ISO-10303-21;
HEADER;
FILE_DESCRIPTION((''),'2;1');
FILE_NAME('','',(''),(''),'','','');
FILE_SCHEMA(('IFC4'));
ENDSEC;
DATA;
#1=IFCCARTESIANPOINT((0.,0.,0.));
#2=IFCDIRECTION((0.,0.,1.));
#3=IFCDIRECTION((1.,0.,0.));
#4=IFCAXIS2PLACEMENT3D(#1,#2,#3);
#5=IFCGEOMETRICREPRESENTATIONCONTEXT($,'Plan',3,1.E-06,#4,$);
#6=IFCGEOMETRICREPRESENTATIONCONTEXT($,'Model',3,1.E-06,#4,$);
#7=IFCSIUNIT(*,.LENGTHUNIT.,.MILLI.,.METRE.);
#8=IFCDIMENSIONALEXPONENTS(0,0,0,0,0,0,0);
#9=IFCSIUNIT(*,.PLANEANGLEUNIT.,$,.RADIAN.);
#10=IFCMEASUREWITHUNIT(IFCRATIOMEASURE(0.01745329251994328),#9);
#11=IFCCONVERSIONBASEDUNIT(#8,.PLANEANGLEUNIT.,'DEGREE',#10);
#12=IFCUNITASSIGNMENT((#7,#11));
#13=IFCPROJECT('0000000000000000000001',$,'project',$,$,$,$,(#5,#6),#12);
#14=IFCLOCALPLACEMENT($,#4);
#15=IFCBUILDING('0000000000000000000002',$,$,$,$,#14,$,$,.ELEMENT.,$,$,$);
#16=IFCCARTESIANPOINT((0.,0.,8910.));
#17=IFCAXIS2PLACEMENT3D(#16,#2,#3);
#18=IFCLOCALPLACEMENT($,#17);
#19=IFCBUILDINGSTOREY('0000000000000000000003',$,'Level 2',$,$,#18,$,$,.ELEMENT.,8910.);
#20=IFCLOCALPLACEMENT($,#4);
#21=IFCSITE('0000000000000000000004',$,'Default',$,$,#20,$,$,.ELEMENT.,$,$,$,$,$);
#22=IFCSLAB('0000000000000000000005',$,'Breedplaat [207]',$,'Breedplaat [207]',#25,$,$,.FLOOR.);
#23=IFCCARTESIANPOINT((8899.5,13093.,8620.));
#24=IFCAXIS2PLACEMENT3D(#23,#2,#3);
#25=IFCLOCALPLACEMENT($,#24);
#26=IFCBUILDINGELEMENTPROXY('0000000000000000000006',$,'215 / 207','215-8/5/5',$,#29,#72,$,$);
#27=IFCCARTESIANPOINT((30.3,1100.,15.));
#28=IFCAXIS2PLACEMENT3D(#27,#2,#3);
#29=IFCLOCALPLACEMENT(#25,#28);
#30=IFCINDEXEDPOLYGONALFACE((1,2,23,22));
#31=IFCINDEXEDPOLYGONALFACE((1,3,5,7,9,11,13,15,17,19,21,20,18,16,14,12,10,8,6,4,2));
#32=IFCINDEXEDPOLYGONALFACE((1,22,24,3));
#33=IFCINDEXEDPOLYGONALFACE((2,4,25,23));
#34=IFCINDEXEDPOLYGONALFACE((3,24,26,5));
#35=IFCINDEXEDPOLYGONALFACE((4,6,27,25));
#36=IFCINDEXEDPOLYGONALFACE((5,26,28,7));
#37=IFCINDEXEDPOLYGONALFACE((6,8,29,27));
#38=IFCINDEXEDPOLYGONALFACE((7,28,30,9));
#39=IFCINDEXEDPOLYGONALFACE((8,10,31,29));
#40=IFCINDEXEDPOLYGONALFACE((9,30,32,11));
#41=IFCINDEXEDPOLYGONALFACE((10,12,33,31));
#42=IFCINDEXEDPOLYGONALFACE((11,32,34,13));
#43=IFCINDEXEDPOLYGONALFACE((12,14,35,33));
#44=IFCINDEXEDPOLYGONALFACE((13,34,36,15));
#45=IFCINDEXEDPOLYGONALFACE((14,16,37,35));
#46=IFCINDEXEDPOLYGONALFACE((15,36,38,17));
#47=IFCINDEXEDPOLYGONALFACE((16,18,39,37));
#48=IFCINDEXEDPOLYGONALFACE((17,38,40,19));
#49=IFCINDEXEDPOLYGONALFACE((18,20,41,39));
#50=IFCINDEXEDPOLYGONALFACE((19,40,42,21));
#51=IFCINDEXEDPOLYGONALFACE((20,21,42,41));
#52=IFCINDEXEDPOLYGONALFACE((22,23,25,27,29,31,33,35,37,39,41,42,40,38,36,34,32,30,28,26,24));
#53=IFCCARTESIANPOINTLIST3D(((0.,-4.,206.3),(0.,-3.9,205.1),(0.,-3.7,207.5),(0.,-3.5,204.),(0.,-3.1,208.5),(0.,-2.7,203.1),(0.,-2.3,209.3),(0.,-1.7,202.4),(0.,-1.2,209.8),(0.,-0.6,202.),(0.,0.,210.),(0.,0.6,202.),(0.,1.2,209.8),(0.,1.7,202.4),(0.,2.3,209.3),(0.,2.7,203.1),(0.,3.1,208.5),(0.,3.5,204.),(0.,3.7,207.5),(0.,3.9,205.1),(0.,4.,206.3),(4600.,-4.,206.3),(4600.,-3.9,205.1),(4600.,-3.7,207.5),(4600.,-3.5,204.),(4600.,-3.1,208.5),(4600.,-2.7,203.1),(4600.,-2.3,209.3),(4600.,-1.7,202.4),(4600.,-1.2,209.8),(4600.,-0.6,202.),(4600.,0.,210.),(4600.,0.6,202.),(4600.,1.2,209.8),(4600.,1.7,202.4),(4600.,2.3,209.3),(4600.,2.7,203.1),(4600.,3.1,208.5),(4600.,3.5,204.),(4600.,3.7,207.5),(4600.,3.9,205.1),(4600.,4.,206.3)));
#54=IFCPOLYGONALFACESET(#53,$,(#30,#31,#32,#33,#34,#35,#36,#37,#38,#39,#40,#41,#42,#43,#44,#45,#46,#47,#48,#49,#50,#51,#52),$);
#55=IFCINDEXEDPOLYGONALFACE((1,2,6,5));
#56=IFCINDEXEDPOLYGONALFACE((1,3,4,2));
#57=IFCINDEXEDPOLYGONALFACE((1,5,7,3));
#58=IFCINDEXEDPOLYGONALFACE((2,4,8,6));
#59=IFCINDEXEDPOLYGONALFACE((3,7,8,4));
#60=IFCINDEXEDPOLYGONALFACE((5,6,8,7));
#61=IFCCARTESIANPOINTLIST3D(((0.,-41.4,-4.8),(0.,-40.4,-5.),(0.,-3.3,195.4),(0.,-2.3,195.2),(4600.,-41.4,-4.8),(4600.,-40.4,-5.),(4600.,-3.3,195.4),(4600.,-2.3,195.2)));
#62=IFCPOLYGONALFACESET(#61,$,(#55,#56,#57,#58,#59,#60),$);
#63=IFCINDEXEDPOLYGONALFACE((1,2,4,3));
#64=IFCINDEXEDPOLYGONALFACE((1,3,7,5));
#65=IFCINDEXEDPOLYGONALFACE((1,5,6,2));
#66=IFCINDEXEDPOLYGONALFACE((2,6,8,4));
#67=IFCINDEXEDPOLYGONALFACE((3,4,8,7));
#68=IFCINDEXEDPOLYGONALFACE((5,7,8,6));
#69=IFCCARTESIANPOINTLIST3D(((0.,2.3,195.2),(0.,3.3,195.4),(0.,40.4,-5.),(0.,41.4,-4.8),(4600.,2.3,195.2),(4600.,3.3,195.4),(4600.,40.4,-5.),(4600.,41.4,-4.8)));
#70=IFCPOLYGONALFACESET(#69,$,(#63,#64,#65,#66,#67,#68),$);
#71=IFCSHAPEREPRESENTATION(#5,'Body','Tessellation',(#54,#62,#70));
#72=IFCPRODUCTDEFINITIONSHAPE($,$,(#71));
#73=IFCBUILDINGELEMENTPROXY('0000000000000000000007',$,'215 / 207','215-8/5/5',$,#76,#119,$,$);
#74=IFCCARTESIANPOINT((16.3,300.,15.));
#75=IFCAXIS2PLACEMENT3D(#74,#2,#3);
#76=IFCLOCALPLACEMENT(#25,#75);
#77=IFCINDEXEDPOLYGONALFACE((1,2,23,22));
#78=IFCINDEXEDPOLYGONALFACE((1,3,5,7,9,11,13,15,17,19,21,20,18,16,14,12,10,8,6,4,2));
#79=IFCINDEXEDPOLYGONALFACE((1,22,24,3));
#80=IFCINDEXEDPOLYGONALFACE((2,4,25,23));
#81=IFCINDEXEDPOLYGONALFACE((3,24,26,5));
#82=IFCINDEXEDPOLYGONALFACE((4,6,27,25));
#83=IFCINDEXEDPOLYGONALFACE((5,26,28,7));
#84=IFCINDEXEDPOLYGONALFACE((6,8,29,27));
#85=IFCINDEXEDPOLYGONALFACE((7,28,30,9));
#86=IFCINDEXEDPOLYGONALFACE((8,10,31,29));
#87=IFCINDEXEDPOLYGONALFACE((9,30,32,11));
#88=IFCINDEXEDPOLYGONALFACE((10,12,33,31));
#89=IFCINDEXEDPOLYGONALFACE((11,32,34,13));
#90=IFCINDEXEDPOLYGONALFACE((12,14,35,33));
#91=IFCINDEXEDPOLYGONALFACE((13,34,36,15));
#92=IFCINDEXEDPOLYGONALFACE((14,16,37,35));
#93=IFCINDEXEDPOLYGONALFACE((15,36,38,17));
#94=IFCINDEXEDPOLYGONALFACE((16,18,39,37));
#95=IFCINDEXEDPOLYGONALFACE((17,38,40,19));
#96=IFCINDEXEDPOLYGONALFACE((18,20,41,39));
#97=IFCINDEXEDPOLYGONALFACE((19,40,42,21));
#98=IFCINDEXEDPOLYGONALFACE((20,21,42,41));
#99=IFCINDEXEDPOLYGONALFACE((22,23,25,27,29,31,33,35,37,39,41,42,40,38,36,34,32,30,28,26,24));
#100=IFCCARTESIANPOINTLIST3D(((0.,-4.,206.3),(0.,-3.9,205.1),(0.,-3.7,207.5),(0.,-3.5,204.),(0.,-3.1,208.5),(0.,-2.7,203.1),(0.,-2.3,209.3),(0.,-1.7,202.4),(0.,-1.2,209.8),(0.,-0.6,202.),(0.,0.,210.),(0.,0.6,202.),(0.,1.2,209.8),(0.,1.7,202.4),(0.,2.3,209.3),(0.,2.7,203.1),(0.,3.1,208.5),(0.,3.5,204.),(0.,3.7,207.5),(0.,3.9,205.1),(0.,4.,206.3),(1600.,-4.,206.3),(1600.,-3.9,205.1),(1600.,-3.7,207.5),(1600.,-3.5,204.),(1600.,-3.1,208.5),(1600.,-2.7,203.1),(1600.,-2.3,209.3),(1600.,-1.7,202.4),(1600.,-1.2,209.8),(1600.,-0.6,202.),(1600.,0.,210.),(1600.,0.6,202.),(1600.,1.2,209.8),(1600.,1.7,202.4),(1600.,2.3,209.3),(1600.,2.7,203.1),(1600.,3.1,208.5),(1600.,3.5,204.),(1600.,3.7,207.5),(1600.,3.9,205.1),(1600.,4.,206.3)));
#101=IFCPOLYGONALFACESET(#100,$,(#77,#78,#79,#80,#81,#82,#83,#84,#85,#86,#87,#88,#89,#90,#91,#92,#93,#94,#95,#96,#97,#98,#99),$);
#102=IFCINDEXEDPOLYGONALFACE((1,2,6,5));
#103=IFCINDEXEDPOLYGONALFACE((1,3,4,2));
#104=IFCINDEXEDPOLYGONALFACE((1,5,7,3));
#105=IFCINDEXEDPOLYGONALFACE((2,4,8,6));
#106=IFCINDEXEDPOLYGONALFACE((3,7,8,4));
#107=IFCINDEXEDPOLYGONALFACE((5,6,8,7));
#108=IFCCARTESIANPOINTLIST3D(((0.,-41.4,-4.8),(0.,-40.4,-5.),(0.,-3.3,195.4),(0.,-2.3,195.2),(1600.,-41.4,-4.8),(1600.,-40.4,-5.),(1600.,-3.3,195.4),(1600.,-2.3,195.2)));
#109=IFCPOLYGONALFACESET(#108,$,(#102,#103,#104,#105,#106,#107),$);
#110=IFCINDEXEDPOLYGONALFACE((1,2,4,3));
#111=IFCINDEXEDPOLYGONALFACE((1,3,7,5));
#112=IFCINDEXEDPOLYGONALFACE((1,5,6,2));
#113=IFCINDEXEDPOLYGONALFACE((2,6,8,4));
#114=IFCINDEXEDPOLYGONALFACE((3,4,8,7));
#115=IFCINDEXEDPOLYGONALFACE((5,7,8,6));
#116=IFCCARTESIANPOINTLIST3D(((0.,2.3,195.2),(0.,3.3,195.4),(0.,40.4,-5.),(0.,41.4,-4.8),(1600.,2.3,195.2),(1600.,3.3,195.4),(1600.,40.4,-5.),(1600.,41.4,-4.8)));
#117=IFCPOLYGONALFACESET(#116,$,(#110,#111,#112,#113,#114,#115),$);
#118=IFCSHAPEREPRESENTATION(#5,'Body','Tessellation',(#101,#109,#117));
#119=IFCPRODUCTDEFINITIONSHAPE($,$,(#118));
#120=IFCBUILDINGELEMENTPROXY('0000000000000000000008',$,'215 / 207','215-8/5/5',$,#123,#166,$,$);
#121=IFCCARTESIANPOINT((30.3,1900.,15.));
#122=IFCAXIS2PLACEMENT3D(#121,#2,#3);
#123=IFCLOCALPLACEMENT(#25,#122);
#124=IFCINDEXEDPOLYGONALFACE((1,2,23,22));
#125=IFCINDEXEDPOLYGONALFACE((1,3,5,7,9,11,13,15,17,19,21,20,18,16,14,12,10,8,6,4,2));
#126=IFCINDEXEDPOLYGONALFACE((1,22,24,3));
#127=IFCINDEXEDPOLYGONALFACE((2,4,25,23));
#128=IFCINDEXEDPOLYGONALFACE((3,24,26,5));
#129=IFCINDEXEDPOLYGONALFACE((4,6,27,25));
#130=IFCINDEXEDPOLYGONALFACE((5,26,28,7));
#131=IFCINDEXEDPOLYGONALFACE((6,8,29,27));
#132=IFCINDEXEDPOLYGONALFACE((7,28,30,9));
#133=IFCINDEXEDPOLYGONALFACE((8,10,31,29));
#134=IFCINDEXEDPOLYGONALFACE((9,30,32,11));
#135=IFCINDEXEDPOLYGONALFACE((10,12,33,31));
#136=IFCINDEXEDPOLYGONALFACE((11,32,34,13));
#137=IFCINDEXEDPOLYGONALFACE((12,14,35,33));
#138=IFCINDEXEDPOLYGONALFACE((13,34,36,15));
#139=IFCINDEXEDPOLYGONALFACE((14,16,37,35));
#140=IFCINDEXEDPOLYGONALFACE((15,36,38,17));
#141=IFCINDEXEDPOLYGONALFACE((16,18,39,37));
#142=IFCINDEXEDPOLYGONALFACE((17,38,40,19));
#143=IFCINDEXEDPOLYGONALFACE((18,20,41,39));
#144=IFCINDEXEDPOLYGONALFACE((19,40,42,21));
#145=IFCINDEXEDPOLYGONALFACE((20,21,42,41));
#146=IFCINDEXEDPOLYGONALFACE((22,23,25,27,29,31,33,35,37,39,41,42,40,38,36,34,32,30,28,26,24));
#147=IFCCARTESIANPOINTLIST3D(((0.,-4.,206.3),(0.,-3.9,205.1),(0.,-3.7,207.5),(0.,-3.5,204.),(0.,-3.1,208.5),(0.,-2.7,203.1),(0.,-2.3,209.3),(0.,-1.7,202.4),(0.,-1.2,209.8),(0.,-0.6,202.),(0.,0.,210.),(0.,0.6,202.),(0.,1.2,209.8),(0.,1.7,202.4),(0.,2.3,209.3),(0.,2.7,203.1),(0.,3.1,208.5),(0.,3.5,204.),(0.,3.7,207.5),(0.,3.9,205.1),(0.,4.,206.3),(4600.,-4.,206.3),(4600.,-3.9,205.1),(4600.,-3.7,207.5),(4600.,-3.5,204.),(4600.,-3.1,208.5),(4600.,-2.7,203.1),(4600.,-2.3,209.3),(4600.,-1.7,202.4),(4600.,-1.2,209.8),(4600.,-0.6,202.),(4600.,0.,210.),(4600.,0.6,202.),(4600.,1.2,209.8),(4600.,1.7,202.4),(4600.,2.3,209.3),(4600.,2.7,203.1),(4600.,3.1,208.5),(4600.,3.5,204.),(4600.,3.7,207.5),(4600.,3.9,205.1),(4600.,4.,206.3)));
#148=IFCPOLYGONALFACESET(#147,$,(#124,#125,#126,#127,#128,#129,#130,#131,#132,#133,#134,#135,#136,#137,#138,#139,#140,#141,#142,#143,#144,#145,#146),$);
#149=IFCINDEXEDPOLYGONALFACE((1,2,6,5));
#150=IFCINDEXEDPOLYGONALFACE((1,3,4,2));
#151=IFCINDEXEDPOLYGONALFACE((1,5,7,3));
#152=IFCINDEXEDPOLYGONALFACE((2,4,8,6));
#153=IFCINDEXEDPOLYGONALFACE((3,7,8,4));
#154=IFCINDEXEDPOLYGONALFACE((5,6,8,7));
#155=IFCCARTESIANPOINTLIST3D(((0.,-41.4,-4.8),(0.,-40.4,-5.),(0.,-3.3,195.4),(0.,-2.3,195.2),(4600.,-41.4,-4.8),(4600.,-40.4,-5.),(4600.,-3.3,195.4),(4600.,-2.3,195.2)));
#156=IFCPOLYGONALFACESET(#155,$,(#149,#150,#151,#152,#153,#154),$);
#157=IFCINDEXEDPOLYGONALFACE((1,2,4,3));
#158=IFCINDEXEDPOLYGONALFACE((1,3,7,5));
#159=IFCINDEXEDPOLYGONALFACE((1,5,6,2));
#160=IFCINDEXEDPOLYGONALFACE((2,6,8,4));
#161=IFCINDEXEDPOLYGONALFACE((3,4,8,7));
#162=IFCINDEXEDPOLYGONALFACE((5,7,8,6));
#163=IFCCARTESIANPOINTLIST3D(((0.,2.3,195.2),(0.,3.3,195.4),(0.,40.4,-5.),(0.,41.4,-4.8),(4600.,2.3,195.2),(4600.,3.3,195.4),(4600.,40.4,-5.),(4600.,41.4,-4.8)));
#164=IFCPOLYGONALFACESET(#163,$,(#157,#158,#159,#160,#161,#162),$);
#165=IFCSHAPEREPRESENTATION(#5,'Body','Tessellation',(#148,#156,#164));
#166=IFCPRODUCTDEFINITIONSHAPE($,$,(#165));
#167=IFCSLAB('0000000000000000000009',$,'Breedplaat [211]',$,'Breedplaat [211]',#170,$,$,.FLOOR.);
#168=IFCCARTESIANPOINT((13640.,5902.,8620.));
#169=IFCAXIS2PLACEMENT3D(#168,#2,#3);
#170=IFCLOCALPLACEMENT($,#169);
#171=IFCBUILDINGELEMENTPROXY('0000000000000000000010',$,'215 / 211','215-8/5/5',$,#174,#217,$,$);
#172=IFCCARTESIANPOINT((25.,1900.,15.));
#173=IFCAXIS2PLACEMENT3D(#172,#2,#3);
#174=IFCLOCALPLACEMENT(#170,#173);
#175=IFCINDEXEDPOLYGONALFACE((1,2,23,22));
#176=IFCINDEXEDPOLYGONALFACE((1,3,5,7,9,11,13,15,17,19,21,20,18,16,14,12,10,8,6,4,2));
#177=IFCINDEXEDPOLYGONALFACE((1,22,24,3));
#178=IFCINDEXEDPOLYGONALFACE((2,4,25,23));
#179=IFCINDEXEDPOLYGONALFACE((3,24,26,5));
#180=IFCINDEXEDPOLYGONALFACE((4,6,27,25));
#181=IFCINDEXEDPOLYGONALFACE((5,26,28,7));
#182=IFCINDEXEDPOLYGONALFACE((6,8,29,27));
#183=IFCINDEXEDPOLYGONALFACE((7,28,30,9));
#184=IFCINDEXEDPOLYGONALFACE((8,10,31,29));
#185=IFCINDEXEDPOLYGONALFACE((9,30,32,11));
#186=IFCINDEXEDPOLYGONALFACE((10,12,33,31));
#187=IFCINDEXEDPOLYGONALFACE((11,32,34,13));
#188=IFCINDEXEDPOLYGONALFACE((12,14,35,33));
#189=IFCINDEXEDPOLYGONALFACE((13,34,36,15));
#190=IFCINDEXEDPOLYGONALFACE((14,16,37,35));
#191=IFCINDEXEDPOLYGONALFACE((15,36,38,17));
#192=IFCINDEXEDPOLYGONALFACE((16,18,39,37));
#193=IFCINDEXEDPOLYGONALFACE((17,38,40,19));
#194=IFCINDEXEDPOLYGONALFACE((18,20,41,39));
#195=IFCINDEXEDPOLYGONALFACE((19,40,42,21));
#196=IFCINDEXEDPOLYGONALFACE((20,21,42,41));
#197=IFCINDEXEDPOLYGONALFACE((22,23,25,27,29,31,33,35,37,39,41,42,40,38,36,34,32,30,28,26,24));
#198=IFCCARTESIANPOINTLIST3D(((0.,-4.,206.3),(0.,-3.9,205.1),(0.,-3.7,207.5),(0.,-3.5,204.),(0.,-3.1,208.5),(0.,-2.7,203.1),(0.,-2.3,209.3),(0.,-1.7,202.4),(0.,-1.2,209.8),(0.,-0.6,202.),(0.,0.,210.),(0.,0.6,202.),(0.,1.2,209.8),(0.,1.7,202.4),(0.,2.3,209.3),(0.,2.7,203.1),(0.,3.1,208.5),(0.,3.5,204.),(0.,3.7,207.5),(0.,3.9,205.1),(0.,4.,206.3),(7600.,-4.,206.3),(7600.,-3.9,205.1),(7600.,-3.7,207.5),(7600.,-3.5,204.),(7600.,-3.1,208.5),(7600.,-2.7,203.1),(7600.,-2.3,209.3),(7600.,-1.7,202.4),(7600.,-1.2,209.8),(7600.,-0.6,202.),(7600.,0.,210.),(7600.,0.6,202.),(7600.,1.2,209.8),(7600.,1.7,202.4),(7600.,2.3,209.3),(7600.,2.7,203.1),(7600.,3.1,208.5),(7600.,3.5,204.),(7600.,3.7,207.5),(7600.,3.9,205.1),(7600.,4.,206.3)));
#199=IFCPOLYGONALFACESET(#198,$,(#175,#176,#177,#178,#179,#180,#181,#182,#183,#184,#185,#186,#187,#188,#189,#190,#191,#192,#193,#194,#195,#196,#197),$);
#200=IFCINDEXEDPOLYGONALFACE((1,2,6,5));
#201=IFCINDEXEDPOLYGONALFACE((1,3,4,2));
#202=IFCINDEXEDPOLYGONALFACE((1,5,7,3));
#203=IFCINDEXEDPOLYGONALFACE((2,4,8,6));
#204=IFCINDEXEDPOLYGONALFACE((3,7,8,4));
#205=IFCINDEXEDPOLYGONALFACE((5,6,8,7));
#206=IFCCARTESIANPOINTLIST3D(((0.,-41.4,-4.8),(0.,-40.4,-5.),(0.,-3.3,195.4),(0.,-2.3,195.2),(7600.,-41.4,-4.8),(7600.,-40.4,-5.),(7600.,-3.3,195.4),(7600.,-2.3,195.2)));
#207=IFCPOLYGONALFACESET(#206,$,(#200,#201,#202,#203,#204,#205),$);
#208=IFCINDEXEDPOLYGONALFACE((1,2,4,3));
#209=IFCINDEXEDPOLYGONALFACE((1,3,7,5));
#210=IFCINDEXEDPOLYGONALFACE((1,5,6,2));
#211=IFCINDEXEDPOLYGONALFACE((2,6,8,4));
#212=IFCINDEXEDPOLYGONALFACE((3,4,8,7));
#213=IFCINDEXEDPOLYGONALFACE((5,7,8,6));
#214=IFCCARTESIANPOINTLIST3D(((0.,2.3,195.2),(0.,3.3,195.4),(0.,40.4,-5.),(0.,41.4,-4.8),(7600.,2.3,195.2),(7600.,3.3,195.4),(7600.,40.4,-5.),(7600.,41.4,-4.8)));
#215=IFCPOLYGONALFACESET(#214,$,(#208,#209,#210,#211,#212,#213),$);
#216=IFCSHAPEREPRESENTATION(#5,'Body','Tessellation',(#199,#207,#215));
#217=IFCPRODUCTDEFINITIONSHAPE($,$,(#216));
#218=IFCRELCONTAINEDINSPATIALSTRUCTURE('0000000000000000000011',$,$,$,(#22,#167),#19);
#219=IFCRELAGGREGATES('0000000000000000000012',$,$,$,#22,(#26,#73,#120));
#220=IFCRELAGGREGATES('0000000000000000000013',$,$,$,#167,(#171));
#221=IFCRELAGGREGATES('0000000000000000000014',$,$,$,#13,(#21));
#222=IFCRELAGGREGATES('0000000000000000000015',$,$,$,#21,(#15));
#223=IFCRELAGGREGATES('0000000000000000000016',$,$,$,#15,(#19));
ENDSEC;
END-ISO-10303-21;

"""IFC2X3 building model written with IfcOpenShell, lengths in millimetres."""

from ifc_helpers import new_model, entity, si_unit, converted_unit, frame, origin_with_axes, origin_2d_with_axis, place, context, project, spatial, rectangle, circle, extrude, element, aggregate, save


model = new_model("IFC2X3")

# Units and contexts
plan_context = context("Plan", 3, precision=1e-06, world=origin_with_axes())
model_context = context("Model", 3, precision=1e-06, world=origin_with_axes())
ifc_project = project(units=[si_unit("LENGTHUNIT", "METRE", prefix="MILLI"), converted_unit("PLANEANGLEUNIT", "DEGREE", entity("IfcRatioMeasure", 0.01745329251994328), si_unit("PLANEANGLEUNIT", "RADIAN"), dimensions=[0, 0, 0, 0, 0, 0, 0])], contexts=[plan_context, model_context])

# Site, building, storey
site_placement = place(None, origin_with_axes())
site = spatial("IfcSite", under=ifc_project, at=site_placement, Name="Default", CompositionType="ELEMENT")
building_placement = place(None, origin_with_axes())
building = spatial("IfcBuilding", under=site, at=building_placement, CompositionType="ELEMENT")
storey_placement = place(None, frame((0.0, 0.0, 8910.0), z_axis=(0.0, 0.0, 1.0), x_axis=(1.0, 0.0, 0.0)))
storey = spatial("IfcBuildingStorey", under=building, at=storey_placement, Name="Level 2", CompositionType="ELEMENT", Elevation=8910.0)

# Slab, building element proxies
slab_1_placement = place(None, frame((8899.5, 13093.0, 8620.0), z_axis=(0.0, 0.0, 1.0), x_axis=(1.0, 0.0, 0.0)))
slab_1 = element("IfcSlab", 1, at=slab_1_placement, inside=storey, Name="Breedplaat [207]", ObjectType="Breedplaat [207]", PredefinedType="FLOOR")
proxy_1_placement = place(slab_1_placement, frame((30.3, 1100.0, 15.0), z_axis=(0.0, 0.0, 1.0), x_axis=(1.0, 0.0, 0.0)))
proxy_1 = element("IfcBuildingElementProxy", 2, at=proxy_1_placement, Name="215 / 207", Description="215-8/5/5", context=plan_context, shape_type="SweptSolid", body=[
    extrude(circle(Radius=4.0, at=origin_2d_with_axis()), frame((0.0, 0.0, 206.0), z_axis=(1.0, 0.0, 0.0), x_axis=(0.0, 0.0, 1.0)), (0.0, 0.0, 1.0), 4600.0),
    extrude(rectangle(XDim=203.8, YDim=1.0, at=origin_2d_with_axis()), frame((0.0, -21.9, 95.2), z_axis=(1.0, 0.0, 0.0), x_axis=(0.0, 0.187112, 0.982339)), (0.0, 0.0, 1.0), 4600.0),
    extrude(rectangle(XDim=203.8, YDim=1.0, at=origin_2d_with_axis()), frame((0.0, 21.9, 95.2), z_axis=(1.0, 0.0, 0.0), x_axis=(0.0, -0.187112, 0.982339)), (0.0, 0.0, 1.0), 4600.0),
])
proxy_2_placement = place(slab_1_placement, frame((16.3, 300.0, 15.0), z_axis=(0.0, 0.0, 1.0), x_axis=(1.0, 0.0, 0.0)))
proxy_2 = element("IfcBuildingElementProxy", 3, at=proxy_2_placement, Name="215 / 207", Description="215-8/5/5", context=plan_context, shape_type="SweptSolid", body=[
    extrude(circle(Radius=4.0, at=origin_2d_with_axis()), frame((0.0, 0.0, 206.0), z_axis=(1.0, 0.0, 0.0), x_axis=(0.0, 0.0, 1.0)), (0.0, 0.0, 1.0), 1600.0),
    extrude(rectangle(XDim=203.8, YDim=1.0, at=origin_2d_with_axis()), frame((0.0, -21.9, 95.2), z_axis=(1.0, 0.0, 0.0), x_axis=(0.0, 0.187112, 0.982339)), (0.0, 0.0, 1.0), 1600.0),
    extrude(rectangle(XDim=203.8, YDim=1.0, at=origin_2d_with_axis()), frame((0.0, 21.9, 95.2), z_axis=(1.0, 0.0, 0.0), x_axis=(0.0, -0.187112, 0.982339)), (0.0, 0.0, 1.0), 1600.0),
])
proxy_3_placement = place(slab_1_placement, frame((30.3, 1900.0, 15.0), z_axis=(0.0, 0.0, 1.0), x_axis=(1.0, 0.0, 0.0)))
proxy_3 = element("IfcBuildingElementProxy", 4, at=proxy_3_placement, Name="215 / 207", Description="215-8/5/5", context=plan_context, shape_type="SweptSolid", body=[
    extrude(circle(Radius=4.0, at=origin_2d_with_axis()), frame((0.0, 0.0, 206.0), z_axis=(1.0, 0.0, 0.0), x_axis=(0.0, 0.0, 1.0)), (0.0, 0.0, 1.0), 4600.0),
    extrude(rectangle(XDim=203.8, YDim=1.0, at=origin_2d_with_axis()), frame((0.0, -21.9, 95.2), z_axis=(1.0, 0.0, 0.0), x_axis=(0.0, 0.187112, 0.982339)), (0.0, 0.0, 1.0), 4600.0),
    extrude(rectangle(XDim=203.8, YDim=1.0, at=origin_2d_with_axis()), frame((0.0, 21.9, 95.2), z_axis=(1.0, 0.0, 0.0), x_axis=(0.0, -0.187112, 0.982339)), (0.0, 0.0, 1.0), 4600.0),
])
aggregate(slab_1, [proxy_1, proxy_2, proxy_3])

# Slab, building element proxy
slab_2_placement = place(None, frame((13640.0, 5902.0, 8620.0), z_axis=(0.0, 0.0, 1.0), x_axis=(1.0, 0.0, 0.0)))
slab_2 = element("IfcSlab", 5, at=slab_2_placement, inside=storey, Name="Breedplaat [211]", ObjectType="Breedplaat [211]", PredefinedType="FLOOR")
proxy_4_placement = place(slab_2_placement, frame((25.0, 1900.0, 15.0), z_axis=(0.0, 0.0, 1.0), x_axis=(1.0, 0.0, 0.0)))
proxy_4 = element("IfcBuildingElementProxy", 6, at=proxy_4_placement, Name="215 / 211", Description="215-8/5/5", context=plan_context, shape_type="SweptSolid", body=[
    extrude(circle(Radius=4.0, at=origin_2d_with_axis()), frame((0.0, 0.0, 206.0), z_axis=(1.0, 0.0, 0.0), x_axis=(0.0, 0.0, 1.0)), (0.0, 0.0, 1.0), 7600.0),
    extrude(rectangle(XDim=203.8, YDim=1.0, at=origin_2d_with_axis()), frame((0.0, -21.9, 95.2), z_axis=(1.0, 0.0, 0.0), x_axis=(0.0, 0.187112, 0.982339)), (0.0, 0.0, 1.0), 7600.0),
    extrude(rectangle(XDim=203.8, YDim=1.0, at=origin_2d_with_axis()), frame((0.0, 21.9, 95.2), z_axis=(1.0, 0.0, 0.0), x_axis=(0.0, -0.187112, 0.982339)), (0.0, 0.0, 1.0), 7600.0),
])
aggregate(slab_2, [proxy_4])

save(model, "model.ifc")
